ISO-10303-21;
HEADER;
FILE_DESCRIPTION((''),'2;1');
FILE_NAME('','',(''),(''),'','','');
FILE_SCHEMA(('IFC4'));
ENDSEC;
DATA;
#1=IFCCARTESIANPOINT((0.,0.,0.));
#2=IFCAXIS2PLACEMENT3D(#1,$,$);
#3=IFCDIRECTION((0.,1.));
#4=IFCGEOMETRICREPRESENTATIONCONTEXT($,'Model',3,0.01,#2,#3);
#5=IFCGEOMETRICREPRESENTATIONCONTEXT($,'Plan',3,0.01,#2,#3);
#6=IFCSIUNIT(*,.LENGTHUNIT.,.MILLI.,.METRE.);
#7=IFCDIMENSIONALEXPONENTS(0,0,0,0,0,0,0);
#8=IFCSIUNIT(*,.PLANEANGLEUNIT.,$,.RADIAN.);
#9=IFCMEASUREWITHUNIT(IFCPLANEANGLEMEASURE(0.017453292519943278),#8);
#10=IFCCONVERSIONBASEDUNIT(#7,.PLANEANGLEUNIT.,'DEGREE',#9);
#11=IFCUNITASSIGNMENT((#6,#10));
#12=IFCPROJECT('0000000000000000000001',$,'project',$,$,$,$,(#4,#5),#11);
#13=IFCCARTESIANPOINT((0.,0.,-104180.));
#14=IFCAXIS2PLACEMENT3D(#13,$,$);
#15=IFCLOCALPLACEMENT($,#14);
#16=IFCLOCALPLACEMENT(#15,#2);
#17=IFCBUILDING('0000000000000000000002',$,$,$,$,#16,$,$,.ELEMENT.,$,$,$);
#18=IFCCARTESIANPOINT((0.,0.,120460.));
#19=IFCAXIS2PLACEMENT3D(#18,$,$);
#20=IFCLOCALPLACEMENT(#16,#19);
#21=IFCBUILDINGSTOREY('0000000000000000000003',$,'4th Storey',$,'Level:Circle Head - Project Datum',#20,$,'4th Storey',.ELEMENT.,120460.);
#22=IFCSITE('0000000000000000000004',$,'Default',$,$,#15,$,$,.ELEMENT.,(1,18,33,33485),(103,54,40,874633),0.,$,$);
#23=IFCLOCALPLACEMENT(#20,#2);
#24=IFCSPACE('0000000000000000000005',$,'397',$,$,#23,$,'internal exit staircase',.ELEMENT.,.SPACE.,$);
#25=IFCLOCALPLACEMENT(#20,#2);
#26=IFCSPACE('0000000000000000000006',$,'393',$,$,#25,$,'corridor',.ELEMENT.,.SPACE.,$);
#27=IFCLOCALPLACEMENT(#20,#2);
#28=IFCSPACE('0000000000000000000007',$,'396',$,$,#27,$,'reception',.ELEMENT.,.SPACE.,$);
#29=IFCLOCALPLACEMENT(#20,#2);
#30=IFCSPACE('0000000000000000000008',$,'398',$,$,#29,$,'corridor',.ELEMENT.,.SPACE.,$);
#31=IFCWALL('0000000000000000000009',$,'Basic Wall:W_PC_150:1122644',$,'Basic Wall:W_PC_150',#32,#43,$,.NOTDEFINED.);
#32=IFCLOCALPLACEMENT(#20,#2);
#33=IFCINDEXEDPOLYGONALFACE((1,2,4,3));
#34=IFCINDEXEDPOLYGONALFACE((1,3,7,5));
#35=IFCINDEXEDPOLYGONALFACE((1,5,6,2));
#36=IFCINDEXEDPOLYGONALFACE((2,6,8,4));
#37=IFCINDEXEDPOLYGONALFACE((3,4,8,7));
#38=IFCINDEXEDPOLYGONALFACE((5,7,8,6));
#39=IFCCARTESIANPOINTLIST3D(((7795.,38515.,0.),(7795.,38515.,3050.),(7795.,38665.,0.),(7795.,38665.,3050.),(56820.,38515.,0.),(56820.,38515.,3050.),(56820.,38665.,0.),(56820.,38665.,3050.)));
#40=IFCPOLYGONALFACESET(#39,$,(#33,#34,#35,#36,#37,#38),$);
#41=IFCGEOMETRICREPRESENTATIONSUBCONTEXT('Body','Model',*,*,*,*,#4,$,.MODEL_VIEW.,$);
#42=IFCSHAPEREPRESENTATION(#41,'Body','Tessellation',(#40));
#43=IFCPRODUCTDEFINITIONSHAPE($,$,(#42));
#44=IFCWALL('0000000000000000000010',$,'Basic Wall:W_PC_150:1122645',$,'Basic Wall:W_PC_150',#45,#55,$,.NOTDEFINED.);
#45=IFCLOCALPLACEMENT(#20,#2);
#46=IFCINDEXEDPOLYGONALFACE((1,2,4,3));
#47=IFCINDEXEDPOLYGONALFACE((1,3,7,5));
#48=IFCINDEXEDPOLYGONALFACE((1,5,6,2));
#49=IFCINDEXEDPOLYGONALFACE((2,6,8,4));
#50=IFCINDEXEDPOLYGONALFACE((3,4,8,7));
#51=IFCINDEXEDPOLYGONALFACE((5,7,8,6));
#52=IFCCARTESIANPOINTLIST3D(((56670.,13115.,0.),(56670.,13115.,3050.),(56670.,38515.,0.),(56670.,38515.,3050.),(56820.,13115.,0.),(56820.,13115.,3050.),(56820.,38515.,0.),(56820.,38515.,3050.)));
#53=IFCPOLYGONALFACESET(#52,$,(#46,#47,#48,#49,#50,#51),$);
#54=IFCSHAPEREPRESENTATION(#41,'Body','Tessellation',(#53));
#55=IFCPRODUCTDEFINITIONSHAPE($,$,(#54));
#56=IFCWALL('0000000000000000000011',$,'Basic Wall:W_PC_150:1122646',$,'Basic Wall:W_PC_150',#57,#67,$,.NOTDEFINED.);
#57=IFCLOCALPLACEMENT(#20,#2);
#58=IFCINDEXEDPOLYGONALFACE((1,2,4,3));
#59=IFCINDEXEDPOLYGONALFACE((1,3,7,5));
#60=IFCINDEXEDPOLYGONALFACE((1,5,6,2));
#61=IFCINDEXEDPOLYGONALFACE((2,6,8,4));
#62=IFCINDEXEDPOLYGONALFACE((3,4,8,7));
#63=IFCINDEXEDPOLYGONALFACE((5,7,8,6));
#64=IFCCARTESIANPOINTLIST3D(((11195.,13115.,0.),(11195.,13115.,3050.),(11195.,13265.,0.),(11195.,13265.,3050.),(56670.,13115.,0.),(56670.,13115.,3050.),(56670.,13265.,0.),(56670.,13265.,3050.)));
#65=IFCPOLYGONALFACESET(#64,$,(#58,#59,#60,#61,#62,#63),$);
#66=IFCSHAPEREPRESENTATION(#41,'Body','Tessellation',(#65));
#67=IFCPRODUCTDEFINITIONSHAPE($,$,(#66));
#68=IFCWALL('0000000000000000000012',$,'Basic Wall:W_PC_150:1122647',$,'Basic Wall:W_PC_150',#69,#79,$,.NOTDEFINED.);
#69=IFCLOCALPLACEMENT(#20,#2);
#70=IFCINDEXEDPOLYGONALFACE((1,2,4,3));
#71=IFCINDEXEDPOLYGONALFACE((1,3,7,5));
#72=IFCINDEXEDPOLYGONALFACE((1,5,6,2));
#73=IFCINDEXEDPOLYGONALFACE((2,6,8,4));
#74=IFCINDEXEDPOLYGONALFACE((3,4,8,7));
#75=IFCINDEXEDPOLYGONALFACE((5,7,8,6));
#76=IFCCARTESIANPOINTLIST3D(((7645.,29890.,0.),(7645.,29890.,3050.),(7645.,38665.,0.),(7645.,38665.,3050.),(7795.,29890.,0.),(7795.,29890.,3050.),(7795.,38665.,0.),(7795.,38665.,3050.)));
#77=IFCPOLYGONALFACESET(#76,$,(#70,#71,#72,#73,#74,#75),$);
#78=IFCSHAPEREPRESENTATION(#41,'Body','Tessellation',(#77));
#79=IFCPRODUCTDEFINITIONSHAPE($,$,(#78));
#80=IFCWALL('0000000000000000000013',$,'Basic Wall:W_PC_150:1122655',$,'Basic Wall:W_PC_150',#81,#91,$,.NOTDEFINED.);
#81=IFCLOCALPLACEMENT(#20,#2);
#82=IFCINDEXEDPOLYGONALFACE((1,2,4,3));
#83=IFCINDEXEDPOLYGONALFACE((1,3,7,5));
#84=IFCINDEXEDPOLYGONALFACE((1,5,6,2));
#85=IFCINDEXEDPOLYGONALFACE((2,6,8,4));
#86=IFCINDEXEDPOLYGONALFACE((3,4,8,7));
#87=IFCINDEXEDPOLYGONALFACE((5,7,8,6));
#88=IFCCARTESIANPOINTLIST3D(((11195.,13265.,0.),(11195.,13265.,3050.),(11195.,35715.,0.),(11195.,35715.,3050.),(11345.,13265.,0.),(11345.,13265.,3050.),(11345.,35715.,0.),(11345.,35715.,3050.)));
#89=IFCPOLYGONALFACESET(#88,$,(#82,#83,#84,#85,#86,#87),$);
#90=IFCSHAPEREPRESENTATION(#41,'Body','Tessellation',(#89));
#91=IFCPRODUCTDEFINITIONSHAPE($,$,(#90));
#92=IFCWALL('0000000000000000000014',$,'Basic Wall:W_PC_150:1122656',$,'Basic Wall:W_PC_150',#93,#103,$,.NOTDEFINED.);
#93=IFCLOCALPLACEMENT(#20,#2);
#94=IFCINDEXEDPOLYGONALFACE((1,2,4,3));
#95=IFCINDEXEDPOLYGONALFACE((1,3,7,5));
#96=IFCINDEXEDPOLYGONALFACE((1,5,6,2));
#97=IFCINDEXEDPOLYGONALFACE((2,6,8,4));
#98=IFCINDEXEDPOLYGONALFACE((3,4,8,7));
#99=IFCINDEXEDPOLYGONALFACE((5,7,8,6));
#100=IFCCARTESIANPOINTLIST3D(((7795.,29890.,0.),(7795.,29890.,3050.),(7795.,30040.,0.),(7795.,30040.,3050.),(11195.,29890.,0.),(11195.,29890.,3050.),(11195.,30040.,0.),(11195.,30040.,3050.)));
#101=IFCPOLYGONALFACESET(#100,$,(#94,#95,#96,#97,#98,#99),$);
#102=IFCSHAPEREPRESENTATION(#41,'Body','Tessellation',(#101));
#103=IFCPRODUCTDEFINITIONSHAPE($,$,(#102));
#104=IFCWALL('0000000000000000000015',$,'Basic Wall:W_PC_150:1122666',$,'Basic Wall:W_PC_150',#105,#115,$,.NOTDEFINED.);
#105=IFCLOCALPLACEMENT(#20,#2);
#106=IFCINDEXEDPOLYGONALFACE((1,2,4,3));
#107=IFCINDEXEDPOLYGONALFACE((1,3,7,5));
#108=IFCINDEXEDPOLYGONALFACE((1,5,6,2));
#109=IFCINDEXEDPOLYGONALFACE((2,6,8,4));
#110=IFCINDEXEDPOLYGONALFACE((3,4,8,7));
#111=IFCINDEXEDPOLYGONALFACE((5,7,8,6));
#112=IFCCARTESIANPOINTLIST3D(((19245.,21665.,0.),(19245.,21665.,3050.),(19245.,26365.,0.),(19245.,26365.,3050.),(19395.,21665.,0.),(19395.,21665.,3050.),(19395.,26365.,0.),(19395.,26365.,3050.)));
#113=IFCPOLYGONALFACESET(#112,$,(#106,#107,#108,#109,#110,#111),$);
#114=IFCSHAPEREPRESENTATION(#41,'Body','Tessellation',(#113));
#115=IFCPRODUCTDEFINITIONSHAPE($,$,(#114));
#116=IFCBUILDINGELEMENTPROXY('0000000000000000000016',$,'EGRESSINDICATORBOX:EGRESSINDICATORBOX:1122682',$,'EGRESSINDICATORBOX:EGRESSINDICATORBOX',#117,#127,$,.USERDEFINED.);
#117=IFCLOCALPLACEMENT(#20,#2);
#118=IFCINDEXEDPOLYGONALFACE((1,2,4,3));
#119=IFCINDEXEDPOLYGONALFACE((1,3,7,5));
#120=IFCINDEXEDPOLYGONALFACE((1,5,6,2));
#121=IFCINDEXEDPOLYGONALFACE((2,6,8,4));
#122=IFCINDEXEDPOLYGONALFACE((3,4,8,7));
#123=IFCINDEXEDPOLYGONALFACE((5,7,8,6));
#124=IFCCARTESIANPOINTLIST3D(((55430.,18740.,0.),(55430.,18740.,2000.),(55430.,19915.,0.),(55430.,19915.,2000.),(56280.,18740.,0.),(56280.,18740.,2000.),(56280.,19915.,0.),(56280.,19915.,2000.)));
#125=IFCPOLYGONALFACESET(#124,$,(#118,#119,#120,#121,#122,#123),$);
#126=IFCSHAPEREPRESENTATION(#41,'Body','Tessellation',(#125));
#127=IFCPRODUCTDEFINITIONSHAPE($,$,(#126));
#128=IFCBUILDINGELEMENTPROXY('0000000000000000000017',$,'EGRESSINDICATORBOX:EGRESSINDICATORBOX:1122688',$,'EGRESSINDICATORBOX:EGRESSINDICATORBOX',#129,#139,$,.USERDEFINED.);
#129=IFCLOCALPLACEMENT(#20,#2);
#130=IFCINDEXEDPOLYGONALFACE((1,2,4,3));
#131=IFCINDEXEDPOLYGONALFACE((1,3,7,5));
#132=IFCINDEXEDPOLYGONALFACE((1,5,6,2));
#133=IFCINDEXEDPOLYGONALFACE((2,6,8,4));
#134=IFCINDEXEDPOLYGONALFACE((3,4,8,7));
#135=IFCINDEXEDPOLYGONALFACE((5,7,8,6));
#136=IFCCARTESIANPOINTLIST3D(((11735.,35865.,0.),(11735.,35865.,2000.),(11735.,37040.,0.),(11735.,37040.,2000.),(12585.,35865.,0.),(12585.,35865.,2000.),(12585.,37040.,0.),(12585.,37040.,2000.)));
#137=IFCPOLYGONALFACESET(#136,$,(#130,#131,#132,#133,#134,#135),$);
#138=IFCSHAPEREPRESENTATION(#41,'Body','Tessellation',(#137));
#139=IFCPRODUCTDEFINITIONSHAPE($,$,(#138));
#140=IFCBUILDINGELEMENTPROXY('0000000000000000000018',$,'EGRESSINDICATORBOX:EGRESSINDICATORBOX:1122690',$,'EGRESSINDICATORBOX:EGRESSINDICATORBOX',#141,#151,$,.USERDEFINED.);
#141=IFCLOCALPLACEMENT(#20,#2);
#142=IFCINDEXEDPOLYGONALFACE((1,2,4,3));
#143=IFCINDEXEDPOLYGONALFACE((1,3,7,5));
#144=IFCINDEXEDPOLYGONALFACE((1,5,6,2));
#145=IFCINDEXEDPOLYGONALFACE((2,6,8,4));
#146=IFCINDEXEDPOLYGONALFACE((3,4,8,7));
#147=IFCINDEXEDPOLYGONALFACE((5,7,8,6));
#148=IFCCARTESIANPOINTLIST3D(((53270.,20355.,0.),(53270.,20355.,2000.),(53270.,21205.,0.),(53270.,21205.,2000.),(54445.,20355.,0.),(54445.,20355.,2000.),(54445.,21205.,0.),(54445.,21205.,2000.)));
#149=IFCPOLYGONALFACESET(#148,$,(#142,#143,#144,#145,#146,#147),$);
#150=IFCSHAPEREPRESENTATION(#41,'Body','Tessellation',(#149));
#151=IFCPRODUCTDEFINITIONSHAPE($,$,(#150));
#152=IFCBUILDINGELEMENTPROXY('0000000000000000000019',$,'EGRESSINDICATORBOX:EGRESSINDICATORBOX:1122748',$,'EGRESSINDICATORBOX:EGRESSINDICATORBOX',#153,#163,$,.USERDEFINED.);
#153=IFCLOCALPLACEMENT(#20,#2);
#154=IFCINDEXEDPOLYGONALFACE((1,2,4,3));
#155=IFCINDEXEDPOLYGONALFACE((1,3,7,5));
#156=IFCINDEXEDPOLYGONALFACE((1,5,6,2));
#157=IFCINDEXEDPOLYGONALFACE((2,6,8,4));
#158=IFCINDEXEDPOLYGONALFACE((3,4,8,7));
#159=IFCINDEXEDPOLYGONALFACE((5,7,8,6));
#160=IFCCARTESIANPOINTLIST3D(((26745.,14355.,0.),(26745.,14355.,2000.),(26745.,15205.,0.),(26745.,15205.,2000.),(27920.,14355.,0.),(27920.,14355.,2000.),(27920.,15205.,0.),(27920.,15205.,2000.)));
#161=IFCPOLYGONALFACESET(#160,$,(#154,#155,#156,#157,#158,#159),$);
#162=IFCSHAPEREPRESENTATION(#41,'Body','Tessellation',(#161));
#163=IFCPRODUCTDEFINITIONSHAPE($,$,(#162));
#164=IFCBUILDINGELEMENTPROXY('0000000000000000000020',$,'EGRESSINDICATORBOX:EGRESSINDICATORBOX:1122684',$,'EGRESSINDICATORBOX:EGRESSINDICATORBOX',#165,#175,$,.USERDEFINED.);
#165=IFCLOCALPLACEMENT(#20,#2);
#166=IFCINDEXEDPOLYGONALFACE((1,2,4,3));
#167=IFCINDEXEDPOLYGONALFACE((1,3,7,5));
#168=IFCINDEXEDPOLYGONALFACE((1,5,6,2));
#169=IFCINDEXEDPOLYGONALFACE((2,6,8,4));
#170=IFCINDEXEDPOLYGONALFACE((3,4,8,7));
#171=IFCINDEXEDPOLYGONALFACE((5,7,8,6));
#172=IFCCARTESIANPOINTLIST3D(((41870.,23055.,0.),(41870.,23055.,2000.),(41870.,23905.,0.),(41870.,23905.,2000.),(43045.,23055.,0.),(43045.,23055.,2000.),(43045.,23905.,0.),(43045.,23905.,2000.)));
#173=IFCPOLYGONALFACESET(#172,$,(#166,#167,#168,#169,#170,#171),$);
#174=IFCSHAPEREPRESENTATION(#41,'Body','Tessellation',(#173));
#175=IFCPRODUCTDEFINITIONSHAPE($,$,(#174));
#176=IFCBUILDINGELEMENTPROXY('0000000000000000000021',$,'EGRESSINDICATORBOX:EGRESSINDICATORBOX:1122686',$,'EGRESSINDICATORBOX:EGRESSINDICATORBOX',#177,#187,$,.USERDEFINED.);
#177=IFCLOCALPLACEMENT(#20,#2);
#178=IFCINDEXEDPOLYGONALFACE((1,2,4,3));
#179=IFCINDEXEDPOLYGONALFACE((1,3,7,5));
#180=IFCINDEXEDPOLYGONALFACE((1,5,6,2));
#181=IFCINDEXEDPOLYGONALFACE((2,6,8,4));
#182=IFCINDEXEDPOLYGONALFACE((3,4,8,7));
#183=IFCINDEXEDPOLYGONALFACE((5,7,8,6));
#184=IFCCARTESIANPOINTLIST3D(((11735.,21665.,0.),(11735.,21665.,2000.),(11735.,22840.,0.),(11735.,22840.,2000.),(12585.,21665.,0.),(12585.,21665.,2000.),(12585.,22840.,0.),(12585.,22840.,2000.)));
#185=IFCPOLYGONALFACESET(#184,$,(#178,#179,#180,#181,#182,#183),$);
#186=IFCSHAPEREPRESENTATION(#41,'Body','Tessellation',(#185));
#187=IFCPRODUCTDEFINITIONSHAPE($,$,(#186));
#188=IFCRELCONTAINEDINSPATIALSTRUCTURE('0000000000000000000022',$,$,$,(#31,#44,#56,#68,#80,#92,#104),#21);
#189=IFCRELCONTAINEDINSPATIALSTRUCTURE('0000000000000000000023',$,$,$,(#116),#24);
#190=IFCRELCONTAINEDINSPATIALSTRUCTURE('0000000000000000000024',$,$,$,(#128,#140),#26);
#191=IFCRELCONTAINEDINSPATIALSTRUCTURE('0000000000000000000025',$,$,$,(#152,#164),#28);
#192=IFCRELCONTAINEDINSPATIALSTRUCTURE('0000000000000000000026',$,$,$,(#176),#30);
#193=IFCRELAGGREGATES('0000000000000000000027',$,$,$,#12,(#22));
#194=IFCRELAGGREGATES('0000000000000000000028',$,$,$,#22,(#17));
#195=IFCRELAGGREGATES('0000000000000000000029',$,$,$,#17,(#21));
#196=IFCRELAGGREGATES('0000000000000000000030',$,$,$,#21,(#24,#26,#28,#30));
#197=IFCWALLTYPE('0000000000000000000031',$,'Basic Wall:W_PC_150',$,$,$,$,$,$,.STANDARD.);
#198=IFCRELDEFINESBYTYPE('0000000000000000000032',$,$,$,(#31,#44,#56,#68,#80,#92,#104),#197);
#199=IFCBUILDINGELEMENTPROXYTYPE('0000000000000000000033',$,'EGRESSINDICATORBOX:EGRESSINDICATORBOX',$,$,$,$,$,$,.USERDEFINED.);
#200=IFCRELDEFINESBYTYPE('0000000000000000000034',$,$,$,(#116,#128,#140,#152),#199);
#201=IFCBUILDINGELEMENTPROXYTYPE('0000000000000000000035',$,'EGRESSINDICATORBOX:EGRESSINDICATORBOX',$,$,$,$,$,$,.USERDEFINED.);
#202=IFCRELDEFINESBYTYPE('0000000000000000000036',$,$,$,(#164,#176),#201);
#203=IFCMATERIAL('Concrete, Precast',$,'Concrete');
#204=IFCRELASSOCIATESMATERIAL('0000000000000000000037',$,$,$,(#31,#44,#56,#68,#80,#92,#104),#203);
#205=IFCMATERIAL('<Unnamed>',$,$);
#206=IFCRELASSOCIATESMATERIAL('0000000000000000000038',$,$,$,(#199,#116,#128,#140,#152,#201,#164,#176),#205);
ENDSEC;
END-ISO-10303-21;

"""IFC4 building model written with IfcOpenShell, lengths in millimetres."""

from ifc_helpers import new_model, entity, si_unit, converted_unit, direction, frame, origin, place, context, subcontext, project, spatial, indexed_curve, outline, extrude, source, transform, mapped, material, type_object, type_shapes, element, save


model = new_model("IFC4")

# Units and contexts
model_context = context("Model", 3, precision=0.01, world=origin(), true_north=direction((0.0, 1.0)))
plan_context = context("Plan", 3, precision=0.01, world=origin(), true_north=direction((0.0, 1.0)))
body_context = subcontext(model_context, "Body", "Model", "MODEL_VIEW")
ifc_project = project(units=[si_unit("LENGTHUNIT", "METRE", prefix="MILLI"), converted_unit("PLANEANGLEUNIT", "DEGREE", entity("IfcPlaneAngleMeasure", 0.017453292519943278), si_unit("PLANEANGLEUNIT", "RADIAN"), dimensions=[0, 0, 0, 0, 0, 0, 0])], contexts=[model_context, plan_context])

# Site, building, storey
site_placement = place(None, frame((0.0, 0.0, -104180.0)))
site = spatial("IfcSite", under=ifc_project, at=site_placement, Name="Default", CompositionType="ELEMENT", RefLatitude=(1, 18, 33, 33485), RefLongitude=(103, 54, 40, 874633), RefElevation=0.0)
building_placement = place(site_placement, origin())
building = spatial("IfcBuilding", under=site, at=building_placement, CompositionType="ELEMENT")
storey_placement = place(building_placement, frame((0.0, 0.0, 120460.0)))
storey = spatial("IfcBuildingStorey", under=building, at=storey_placement, Name="4th Storey", ObjectType="Level:Circle Head - Project Datum", LongName="4th Storey", CompositionType="ELEMENT", Elevation=120460.0)

# Shared definitions
ifc_material_1 = material(Name="Concrete, Precast", Category="Concrete")

# Walls
wall_type = type_object("IfcWallType", Name="Basic Wall:W_PC_150", PredefinedType="STANDARD")
wall_1_placement = place(storey_placement, frame((56820.0, 38590.0, 0.0), z_axis=(0.0, 0.0, 1.0), x_axis=(-1.0, 0.0, 0.0)))
element("IfcWall", 1, at=wall_1_placement, inside=storey, type_object=wall_type, material=ifc_material_1, Name="Basic Wall:W_PC_150:1122644", ObjectType="Basic Wall:W_PC_150", PredefinedType="NOTDEFINED", context=body_context, shape_type="SweptSolid", body=[
    extrude(outline(indexed_curve([(49025.0, 75.0), (0.0, 75.0), (0.0, -75.0), (49025.0, -75.0), (49025.0, 75.0)], self_intersect=False)), origin(), (0.0, 0.0, 1.0), 3050.0),
])
wall_2_placement = place(storey_placement, frame((56745.0, 13115.0, 0.0), z_axis=(0.0, 0.0, 1.0), x_axis=(0.0, 1.0, 0.0)))
element("IfcWall", 2, at=wall_2_placement, inside=storey, type_object=wall_type, material=ifc_material_1, Name="Basic Wall:W_PC_150:1122645", ObjectType="Basic Wall:W_PC_150", PredefinedType="NOTDEFINED", context=body_context, shape_type="SweptSolid", body=[
    extrude(outline(indexed_curve([(25400.0, 75.0), (0.0, 75.0), (0.0, -75.0), (25400.0, -75.0), (25400.0, 75.0)], self_intersect=False)), origin(), (0.0, 0.0, 1.0), 3050.0),
])
wall_3_placement = place(storey_placement, frame((11195.0, 13190.0, 0.0)))
element("IfcWall", 3, at=wall_3_placement, inside=storey, type_object=wall_type, material=ifc_material_1, Name="Basic Wall:W_PC_150:1122646", ObjectType="Basic Wall:W_PC_150", PredefinedType="NOTDEFINED", context=body_context, shape_type="SweptSolid", body=[
    extrude(outline(indexed_curve([(45475.0, 75.0), (0.0, 75.0), (0.0, -75.0), (45475.0, -75.0), (45475.0, 75.0)], self_intersect=False)), origin(), (0.0, 0.0, 1.0), 3050.0),
])
wall_4_placement = place(storey_placement, frame((7720.0, 38665.0, 0.0), z_axis=(0.0, 0.0, 1.0), x_axis=(0.0, -1.0, 0.0)))
element("IfcWall", 4, at=wall_4_placement, inside=storey, type_object=wall_type, material=ifc_material_1, Name="Basic Wall:W_PC_150:1122647", ObjectType="Basic Wall:W_PC_150", PredefinedType="NOTDEFINED", context=body_context, shape_type="SweptSolid", body=[
    extrude(outline(indexed_curve([(8775.0, 75.0), (0.0, 75.0), (0.0, -75.0), (8775.0, -75.0), (8775.0, 75.0)], self_intersect=False)), origin(), (0.0, 0.0, 1.0), 3050.0),
])
wall_5_placement = place(storey_placement, frame((11270.0, 35715.0, 0.0), z_axis=(0.0, 0.0, 1.0), x_axis=(0.0, -1.0, 0.0)))
element("IfcWall", 5, at=wall_5_placement, inside=storey, type_object=wall_type, material=ifc_material_1, Name="Basic Wall:W_PC_150:1122655", ObjectType="Basic Wall:W_PC_150", PredefinedType="NOTDEFINED", context=body_context, shape_type="SweptSolid", body=[
    extrude(outline(indexed_curve([(22450.0, 75.0), (0.0, 75.0), (0.0, -75.0), (22450.0, -75.0), (22450.0, 75.0)], self_intersect=False)), origin(), (0.0, 0.0, 1.0), 3050.0),
])
wall_6_placement = place(storey_placement, frame((7795.0, 29965.0, 0.0)))
element("IfcWall", 6, at=wall_6_placement, inside=storey, type_object=wall_type, material=ifc_material_1, Name="Basic Wall:W_PC_150:1122656", ObjectType="Basic Wall:W_PC_150", PredefinedType="NOTDEFINED", context=body_context, shape_type="SweptSolid", body=[
    extrude(outline(indexed_curve([(3400.0, 75.0), (0.0, 75.0), (0.0, -75.0), (3400.0, -75.0), (3400.0, 75.0)], self_intersect=False)), origin(), (0.0, 0.0, 1.0), 3050.0),
])
wall_7_placement = place(storey_placement, frame((19320.0, 21665.0, 0.0), z_axis=(0.0, 0.0, 1.0), x_axis=(0.0, 1.0, 0.0)))
element("IfcWall", 7, at=wall_7_placement, inside=storey, type_object=wall_type, material=ifc_material_1, Name="Basic Wall:W_PC_150:1122666", ObjectType="Basic Wall:W_PC_150", PredefinedType="NOTDEFINED", context=body_context, shape_type="SweptSolid", body=[
    extrude(outline(indexed_curve([(4700.0, 75.0), (0.0, 75.0), (0.0, -75.0), (4700.0, -75.0), (4700.0, 75.0)], self_intersect=False)), origin(), (0.0, 0.0, 1.0), 3050.0),
])

# Shared definitions
space_1_placement = place(storey_placement, origin())
space_1 = spatial("IfcSpace", under=storey, at=space_1_placement, Name="397", LongName="internal exit staircase", CompositionType="ELEMENT", PredefinedType="SPACE")

# Building element proxy
ifc_material_2 = material(Name="<Unnamed>")
building_element_proxy_type_1 = type_object("IfcBuildingElementProxyType", Name="EGRESSINDICATORBOX:EGRESSINDICATORBOX", PredefinedType="USERDEFINED", material=ifc_material_2)
shared_shape_1 = source(origin(), body_context, "Body", "SweptSolid", [
    extrude(outline(indexed_curve([(-587.5, -425.0), (587.5, -425.0), (587.5, 425.0), (-587.5, 425.0), (-587.5, -425.0)], self_intersect=False)), frame((0.0, 0.0, 0.0), z_axis=(0.0, 0.0, 1.0), x_axis=(0.0, 1.0, 0.0)), (0.0, 0.0, 1.0), 2000.0),
])
type_shapes(building_element_proxy_type_1, [shared_shape_1])
proxy_1_placement = place(space_1_placement, frame((55855.0, 19327.5, 0.0)))
element("IfcBuildingElementProxy", 8, at=proxy_1_placement, inside=space_1, type_object=building_element_proxy_type_1, material=ifc_material_2, Name="EGRESSINDICATORBOX:EGRESSINDICATORBOX:1122682", ObjectType="EGRESSINDICATORBOX:EGRESSINDICATORBOX", PredefinedType="USERDEFINED", context=body_context, shape_type="MappedRepresentation", body=[
    mapped(shared_shape_1, transform((0.0, 0.0, 0.0), scale=1.0)),
])

# Shared definitions
space_2_placement = place(storey_placement, origin())
space_2 = spatial("IfcSpace", under=storey, at=space_2_placement, Name="393", LongName="corridor", CompositionType="ELEMENT", PredefinedType="SPACE")

# Building element proxies
for number, where, z_axis, x_axis, name in (
    (9, (12160.0, 36452.5, 0.0), (0.0, 0.0, 1.0), (-1.0, 0.0, 0.0), "EGRESSINDICATORBOX:EGRESSINDICATORBOX:1122688"),
    (10, (53857.5, 20780.0, 0.0), (0.0, 0.0, 1.0), (0.0, 1.0, 0.0), "EGRESSINDICATORBOX:EGRESSINDICATORBOX:1122690"),
):
    element("IfcBuildingElementProxy", number, at=place(space_2_placement, frame(where, z_axis=z_axis, x_axis=x_axis)), inside=space_2, type_object=building_element_proxy_type_1, material=ifc_material_2, Name=name, ObjectType="EGRESSINDICATORBOX:EGRESSINDICATORBOX", PredefinedType="USERDEFINED", context=body_context, shape_type="MappedRepresentation", body=[
        mapped(shared_shape_1, transform((0.0, 0.0, 0.0), scale=1.0)),
    ])

# Shared definitions
space_3_placement = place(storey_placement, origin())
space_3 = spatial("IfcSpace", under=storey, at=space_3_placement, Name="396", LongName="reception", CompositionType="ELEMENT", PredefinedType="SPACE")

# Building element proxies
proxy_2_placement = place(space_3_placement, frame((27332.5, 14780.0, 0.0), z_axis=(0.0, 0.0, 1.0), x_axis=(0.0, 1.0, 0.0)))
element("IfcBuildingElementProxy", 11, at=proxy_2_placement, inside=space_3, type_object=building_element_proxy_type_1, material=ifc_material_2, Name="EGRESSINDICATORBOX:EGRESSINDICATORBOX:1122748", ObjectType="EGRESSINDICATORBOX:EGRESSINDICATORBOX", PredefinedType="USERDEFINED", context=body_context, shape_type="MappedRepresentation", body=[
    mapped(shared_shape_1, transform((0.0, 0.0, 0.0), scale=1.0)),
])
building_element_proxy_type_2 = type_object("IfcBuildingElementProxyType", Name="EGRESSINDICATORBOX:EGRESSINDICATORBOX", PredefinedType="USERDEFINED", material=ifc_material_2)
shared_shape_2 = source(origin(), body_context, "Body", "SweptSolid", [
    extrude(outline(indexed_curve([(-425.0, -587.5), (425.0, -587.5), (425.0, 587.5), (-425.0, 587.5), (-425.0, -587.5)], self_intersect=False)), frame((0.0, 0.0, 0.0), z_axis=(0.0, 0.0, 1.0), x_axis=(-1.0, 0.0, 0.0)), (0.0, 0.0, 1.0), 2000.0),
])
type_shapes(building_element_proxy_type_2, [shared_shape_2])
proxy_3_placement = place(space_3_placement, frame((42457.5, 23480.0, 0.0), z_axis=(0.0, 0.0, 1.0), x_axis=(0.0, -1.0, 0.0)))
element("IfcBuildingElementProxy", 12, at=proxy_3_placement, inside=space_3, type_object=building_element_proxy_type_2, material=ifc_material_2, Name="EGRESSINDICATORBOX:EGRESSINDICATORBOX:1122684", ObjectType="EGRESSINDICATORBOX:EGRESSINDICATORBOX", PredefinedType="USERDEFINED", context=body_context, shape_type="MappedRepresentation", body=[
    mapped(shared_shape_2, transform((0.0, 0.0, 0.0), scale=1.0)),
])

# Shared definitions
space_4_placement = place(storey_placement, origin())
space_4 = spatial("IfcSpace", under=storey, at=space_4_placement, Name="398", LongName="corridor", CompositionType="ELEMENT", PredefinedType="SPACE")

# Building element proxy
proxy_4_placement = place(space_4_placement, frame((12160.0, 22252.5, 0.0)))
element("IfcBuildingElementProxy", 13, at=proxy_4_placement, inside=space_4, type_object=building_element_proxy_type_2, material=ifc_material_2, Name="EGRESSINDICATORBOX:EGRESSINDICATORBOX:1122686", ObjectType="EGRESSINDICATORBOX:EGRESSINDICATORBOX", PredefinedType="USERDEFINED", context=body_context, shape_type="MappedRepresentation", body=[
    mapped(shared_shape_2, transform((0.0, 0.0, 0.0), scale=1.0)),
])

save(model, "model.ifc")
